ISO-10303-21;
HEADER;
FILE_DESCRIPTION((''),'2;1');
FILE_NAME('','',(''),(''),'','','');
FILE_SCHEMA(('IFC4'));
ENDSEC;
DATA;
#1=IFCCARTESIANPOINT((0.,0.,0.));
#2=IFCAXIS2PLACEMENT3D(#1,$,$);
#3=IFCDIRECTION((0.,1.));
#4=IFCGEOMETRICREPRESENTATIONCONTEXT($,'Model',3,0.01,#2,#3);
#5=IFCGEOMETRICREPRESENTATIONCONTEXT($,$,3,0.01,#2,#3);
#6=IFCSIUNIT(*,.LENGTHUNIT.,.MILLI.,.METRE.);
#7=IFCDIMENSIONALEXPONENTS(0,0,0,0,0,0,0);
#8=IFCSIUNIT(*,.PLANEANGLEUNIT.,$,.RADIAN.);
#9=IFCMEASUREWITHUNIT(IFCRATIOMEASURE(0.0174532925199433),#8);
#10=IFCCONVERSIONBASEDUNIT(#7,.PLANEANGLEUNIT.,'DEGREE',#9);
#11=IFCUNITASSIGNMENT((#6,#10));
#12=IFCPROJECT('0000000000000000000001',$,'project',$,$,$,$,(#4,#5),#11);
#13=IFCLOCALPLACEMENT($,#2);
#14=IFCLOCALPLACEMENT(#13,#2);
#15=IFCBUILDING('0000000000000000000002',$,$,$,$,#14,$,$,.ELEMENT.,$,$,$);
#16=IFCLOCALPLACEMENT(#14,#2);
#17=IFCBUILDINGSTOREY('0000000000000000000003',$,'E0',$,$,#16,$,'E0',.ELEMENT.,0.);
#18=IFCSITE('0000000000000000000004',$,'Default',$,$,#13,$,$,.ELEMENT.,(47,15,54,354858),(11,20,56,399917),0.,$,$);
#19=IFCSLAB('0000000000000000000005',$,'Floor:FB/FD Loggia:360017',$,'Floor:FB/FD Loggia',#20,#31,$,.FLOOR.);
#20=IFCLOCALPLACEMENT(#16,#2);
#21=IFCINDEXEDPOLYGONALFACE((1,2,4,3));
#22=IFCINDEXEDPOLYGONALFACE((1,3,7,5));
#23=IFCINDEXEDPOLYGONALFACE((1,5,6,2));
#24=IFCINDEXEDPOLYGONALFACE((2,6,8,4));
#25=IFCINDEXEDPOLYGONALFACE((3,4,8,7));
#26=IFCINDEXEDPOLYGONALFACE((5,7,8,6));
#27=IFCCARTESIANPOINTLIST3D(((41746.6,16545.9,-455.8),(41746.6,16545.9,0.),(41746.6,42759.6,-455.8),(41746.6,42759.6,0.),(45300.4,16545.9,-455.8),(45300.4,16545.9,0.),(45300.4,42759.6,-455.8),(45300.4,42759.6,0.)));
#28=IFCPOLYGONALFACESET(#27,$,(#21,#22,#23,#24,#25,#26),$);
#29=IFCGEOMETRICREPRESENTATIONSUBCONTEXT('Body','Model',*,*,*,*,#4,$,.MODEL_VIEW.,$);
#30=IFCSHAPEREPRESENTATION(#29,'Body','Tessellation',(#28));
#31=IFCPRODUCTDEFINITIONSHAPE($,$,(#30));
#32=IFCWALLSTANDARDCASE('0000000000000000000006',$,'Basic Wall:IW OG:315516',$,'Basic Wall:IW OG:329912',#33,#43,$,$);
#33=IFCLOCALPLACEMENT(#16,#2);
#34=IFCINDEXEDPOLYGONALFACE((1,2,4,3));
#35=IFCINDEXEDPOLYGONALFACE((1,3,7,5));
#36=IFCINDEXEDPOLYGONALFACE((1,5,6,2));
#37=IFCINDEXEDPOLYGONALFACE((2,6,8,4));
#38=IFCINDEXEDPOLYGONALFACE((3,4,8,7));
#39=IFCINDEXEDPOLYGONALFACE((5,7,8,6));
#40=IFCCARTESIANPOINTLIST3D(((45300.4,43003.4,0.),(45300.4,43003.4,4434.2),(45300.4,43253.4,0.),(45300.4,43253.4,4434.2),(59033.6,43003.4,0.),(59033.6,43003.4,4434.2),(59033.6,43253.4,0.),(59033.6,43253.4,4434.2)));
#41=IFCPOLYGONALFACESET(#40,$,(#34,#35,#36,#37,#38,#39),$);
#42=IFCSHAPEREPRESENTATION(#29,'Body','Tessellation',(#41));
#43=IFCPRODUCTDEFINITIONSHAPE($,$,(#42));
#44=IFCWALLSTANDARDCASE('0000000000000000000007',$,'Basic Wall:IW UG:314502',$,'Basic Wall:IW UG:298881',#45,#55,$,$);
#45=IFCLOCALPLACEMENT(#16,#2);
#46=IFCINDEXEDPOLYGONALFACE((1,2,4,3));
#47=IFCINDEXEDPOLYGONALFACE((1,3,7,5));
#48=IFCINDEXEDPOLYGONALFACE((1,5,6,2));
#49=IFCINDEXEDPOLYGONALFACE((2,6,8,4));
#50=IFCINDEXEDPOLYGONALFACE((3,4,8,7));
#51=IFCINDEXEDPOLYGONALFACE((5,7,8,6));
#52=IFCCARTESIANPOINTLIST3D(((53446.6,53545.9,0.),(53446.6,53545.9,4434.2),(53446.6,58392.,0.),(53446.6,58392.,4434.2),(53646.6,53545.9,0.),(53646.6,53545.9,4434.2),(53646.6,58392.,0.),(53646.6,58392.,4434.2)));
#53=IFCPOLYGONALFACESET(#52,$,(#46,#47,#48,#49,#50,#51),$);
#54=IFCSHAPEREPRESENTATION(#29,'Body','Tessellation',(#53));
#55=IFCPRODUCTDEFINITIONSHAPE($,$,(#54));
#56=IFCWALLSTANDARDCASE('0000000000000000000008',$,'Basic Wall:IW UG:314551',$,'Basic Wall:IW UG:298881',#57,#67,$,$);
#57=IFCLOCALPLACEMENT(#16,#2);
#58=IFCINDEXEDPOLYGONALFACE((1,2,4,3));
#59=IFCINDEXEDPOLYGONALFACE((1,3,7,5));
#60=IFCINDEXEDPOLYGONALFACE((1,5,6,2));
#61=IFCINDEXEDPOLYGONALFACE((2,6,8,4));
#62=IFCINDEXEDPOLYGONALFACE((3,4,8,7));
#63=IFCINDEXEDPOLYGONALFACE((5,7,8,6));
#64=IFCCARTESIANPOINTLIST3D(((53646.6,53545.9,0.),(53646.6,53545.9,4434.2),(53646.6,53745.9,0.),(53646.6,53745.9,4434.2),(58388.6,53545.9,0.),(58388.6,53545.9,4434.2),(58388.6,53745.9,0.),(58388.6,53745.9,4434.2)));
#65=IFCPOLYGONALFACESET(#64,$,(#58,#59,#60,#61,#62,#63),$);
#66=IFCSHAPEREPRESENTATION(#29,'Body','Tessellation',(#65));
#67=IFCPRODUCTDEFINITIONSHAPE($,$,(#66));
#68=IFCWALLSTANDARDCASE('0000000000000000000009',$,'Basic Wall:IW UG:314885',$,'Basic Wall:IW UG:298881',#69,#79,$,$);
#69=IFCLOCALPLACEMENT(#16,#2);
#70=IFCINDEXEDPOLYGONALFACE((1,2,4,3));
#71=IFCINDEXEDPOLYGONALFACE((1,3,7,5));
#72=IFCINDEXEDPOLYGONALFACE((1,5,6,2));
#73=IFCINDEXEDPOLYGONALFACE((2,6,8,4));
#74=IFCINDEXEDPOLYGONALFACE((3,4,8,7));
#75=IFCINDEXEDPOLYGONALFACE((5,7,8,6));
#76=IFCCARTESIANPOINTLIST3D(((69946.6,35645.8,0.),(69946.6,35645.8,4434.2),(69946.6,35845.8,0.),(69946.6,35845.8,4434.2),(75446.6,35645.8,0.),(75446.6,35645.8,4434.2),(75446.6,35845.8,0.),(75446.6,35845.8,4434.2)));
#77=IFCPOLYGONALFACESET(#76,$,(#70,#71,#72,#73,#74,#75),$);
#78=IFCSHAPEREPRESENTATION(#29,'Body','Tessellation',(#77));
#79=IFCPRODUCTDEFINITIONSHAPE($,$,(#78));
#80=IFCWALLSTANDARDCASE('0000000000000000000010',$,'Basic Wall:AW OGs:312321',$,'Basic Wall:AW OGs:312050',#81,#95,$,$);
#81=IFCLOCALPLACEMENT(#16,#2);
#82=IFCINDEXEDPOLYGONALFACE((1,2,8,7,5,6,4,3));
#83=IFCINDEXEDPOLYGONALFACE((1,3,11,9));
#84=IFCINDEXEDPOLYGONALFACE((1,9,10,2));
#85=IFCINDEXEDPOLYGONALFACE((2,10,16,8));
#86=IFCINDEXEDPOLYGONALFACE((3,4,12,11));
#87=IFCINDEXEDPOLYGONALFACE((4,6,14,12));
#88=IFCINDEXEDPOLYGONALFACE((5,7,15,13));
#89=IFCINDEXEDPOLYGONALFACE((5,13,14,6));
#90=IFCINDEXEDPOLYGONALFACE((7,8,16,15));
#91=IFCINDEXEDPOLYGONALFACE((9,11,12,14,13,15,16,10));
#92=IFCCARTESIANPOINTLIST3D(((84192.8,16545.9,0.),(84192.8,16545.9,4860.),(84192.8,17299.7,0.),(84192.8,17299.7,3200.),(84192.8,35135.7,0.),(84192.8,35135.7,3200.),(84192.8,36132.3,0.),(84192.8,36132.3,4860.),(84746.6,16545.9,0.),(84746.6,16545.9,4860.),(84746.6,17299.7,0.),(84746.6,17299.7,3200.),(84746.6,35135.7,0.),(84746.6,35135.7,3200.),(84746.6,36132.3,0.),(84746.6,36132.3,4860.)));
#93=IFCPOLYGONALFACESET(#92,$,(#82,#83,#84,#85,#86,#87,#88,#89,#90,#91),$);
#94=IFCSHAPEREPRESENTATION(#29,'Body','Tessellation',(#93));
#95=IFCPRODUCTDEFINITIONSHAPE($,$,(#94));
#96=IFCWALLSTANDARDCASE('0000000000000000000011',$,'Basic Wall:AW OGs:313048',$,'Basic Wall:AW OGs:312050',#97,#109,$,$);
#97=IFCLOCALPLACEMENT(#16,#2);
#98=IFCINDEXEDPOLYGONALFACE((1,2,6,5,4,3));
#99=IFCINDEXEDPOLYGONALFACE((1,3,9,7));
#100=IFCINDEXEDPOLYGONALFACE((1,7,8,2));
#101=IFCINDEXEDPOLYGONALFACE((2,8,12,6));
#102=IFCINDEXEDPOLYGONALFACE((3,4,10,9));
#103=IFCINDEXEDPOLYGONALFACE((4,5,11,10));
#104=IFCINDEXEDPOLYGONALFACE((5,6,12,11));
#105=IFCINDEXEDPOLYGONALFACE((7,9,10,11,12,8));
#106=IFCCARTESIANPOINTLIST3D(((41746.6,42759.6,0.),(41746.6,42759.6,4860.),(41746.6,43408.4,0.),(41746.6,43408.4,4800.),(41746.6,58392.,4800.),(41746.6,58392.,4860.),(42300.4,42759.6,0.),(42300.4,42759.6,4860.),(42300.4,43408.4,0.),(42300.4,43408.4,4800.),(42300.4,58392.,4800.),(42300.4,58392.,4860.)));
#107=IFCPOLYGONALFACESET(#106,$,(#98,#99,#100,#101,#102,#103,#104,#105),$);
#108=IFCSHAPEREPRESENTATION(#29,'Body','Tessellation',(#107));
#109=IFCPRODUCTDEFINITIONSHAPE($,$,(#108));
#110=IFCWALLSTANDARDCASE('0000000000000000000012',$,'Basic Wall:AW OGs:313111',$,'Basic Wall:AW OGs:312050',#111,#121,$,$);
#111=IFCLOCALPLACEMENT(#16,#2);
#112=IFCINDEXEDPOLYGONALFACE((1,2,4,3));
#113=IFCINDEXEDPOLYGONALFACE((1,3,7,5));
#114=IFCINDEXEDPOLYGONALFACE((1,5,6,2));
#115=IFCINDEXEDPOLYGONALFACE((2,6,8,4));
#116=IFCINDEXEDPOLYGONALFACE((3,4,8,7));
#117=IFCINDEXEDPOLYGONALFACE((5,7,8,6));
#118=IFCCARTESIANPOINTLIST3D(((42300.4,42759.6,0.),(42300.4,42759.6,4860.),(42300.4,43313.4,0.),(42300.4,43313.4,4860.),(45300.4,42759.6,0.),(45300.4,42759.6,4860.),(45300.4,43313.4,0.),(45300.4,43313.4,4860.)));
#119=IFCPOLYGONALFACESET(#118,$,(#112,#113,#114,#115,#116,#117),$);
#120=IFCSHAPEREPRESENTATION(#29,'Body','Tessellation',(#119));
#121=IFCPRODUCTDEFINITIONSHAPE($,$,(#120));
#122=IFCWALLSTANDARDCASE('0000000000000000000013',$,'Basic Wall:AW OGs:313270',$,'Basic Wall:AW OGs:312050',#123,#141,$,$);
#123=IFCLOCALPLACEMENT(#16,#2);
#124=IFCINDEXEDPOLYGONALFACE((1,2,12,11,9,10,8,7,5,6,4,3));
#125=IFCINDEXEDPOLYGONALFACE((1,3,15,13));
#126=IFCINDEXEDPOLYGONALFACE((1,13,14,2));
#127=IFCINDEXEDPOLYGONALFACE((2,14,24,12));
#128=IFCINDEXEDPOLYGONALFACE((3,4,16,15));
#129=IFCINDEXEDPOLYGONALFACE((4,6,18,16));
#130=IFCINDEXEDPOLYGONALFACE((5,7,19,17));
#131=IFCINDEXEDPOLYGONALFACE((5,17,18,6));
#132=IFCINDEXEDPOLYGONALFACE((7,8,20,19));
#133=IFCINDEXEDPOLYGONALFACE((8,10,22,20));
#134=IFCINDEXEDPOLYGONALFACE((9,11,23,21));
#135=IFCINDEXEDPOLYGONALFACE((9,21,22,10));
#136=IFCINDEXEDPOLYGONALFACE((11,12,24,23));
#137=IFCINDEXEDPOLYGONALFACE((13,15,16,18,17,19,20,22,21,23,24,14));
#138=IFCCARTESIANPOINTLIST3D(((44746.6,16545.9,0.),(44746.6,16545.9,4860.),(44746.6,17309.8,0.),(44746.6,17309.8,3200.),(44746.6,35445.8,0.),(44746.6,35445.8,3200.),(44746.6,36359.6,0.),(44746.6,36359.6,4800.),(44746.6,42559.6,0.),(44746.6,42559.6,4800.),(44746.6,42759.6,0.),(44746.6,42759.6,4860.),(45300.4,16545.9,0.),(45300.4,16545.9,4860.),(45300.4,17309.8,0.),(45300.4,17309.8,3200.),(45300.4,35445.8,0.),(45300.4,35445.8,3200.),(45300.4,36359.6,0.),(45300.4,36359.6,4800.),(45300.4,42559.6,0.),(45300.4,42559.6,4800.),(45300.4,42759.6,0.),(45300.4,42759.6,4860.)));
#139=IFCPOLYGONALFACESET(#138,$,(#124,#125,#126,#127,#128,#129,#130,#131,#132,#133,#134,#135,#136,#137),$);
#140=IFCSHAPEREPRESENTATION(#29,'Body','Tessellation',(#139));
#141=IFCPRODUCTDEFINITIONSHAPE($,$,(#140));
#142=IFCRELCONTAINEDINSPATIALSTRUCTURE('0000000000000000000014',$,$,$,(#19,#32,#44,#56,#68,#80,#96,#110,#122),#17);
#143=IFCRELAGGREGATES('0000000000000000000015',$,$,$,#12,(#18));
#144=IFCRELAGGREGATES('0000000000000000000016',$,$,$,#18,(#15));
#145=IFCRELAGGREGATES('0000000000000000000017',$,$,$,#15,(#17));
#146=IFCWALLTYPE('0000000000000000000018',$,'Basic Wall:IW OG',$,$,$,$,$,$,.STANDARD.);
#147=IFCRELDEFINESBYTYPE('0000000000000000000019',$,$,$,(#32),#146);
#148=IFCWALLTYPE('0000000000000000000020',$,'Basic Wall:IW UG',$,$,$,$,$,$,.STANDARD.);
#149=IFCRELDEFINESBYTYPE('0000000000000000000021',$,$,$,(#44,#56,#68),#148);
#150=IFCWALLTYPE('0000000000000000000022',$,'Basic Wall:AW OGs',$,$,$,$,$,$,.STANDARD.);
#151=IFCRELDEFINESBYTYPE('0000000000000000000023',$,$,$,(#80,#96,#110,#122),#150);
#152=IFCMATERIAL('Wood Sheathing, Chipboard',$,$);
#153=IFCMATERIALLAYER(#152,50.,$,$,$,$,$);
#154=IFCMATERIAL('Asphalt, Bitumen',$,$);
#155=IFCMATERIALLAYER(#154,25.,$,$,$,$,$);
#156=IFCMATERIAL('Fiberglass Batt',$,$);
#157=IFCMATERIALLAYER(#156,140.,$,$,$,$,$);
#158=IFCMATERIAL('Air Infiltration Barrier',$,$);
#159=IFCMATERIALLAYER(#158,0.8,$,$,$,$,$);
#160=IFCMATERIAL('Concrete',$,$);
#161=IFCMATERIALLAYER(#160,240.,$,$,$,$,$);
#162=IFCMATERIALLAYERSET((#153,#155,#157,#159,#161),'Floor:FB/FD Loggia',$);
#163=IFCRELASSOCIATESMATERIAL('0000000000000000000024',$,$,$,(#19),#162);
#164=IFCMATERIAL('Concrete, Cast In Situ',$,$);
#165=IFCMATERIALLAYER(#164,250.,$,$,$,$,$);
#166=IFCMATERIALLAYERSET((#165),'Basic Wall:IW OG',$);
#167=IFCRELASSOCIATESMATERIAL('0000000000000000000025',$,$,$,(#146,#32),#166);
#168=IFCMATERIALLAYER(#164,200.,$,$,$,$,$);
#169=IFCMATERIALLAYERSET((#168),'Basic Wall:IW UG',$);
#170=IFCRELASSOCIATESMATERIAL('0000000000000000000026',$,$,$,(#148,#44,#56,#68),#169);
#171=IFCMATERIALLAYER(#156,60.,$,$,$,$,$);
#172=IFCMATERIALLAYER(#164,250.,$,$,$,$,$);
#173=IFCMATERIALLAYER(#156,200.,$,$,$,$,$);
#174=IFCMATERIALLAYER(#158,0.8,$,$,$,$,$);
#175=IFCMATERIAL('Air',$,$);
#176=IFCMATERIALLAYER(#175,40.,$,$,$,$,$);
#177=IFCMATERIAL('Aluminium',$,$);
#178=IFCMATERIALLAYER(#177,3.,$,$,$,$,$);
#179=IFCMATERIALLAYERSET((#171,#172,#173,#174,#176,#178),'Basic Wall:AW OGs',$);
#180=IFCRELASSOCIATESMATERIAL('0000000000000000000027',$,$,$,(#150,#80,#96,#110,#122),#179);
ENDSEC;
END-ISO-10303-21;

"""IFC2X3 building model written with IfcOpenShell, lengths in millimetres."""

from ifc_helpers import new_model, entity, si_unit, converted_unit, direction, frame, frame_2d, origin, place, context, subcontext, project, spatial, polyline, rectangle, extrude, clip, bounded_halfspace, material, layer, layer_set, layer_usage, type_object, element, save


model = new_model("IFC2X3")

# Units and contexts
model_context = context("Model", 3, precision=0.01, world=origin(), true_north=direction((0.0, 1.0)))
context_of_model = context(None, 3, precision=0.01, world=origin(), true_north=direction((0.0, 1.0)))
body_context = subcontext(model_context, "Body", "Model", "MODEL_VIEW")
ifc_project = project(units=[si_unit("LENGTHUNIT", "METRE", prefix="MILLI"), converted_unit("PLANEANGLEUNIT", "DEGREE", entity("IfcRatioMeasure", 0.0174532925199433), si_unit("PLANEANGLEUNIT", "RADIAN"), dimensions=[0, 0, 0, 0, 0, 0, 0])], contexts=[model_context, context_of_model])

# Site, building, storey
site_placement = place(None, origin())
site = spatial("IfcSite", under=ifc_project, at=site_placement, Name="Default", CompositionType="ELEMENT", RefLatitude=(47, 15, 54, 354858), RefLongitude=(11, 20, 56, 399917), RefElevation=0.0)
building_placement = place(site_placement, origin())
building = spatial("IfcBuilding", under=site, at=building_placement, CompositionType="ELEMENT")
storey_placement = place(building_placement, origin())
storey = spatial("IfcBuildingStorey", under=building, at=storey_placement, Name="E0", LongName="E0", CompositionType="ELEMENT", Elevation=0.0)

# Slab
ifc_material_1 = material(Name="Air Infiltration Barrier")
ifc_material_2 = material(Name="Fiberglass Batt")
ifc_material_3 = material(Name="Concrete")
ifc_material_4 = material(Name="Wood Sheathing, Chipboard")
ifc_layer_1 = layer(ifc_material_4, 50.0)
ifc_material_5 = material(Name="Asphalt, Bitumen")
ifc_layer_2 = layer(ifc_material_5, 25.0)
ifc_layer_3 = layer(ifc_material_2, 140.0)
ifc_layer_4 = layer(ifc_material_1, 0.8)
ifc_layer_5 = layer(ifc_material_3, 240.0)
ifc_layer_set_1 = layer_set([ifc_layer_1, ifc_layer_2, ifc_layer_3, ifc_layer_4, ifc_layer_5], Name="Floor:FB/FD Loggia")
ifc_layer_usage_1 = layer_usage(ifc_layer_set_1, "AXIS3", "POSITIVE", 0.0)
slab_1_placement = place(storey_placement, origin())
element("IfcSlab", 1, at=slab_1_placement, inside=storey, material=ifc_layer_usage_1, Name="Floor:FB/FD Loggia:360017", ObjectType="Floor:FB/FD Loggia", PredefinedType="FLOOR", context=body_context, shape_type="SweptSolid", body=[
    extrude(rectangle(XDim=26213.8, YDim=3553.8, at=frame_2d((0.0, 0.0), x_axis=(1.0, 0.0))), frame((43523.5, 29652.7, 0.0), z_axis=(0.0, 0.0, -1.0), x_axis=(0.0, 1.0, 0.0)), (0.0, 0.0, 1.0), 455.8),
])

# Walls
ifc_material_6 = material(Name="Concrete, Cast In Situ")
ifc_layer_6 = layer(ifc_material_6, 250.0)
ifc_layer_set_2 = layer_set([ifc_layer_6], Name="Basic Wall:IW OG")
wall_type_1 = type_object("IfcWallType", Name="Basic Wall:IW OG", PredefinedType="STANDARD", material=ifc_layer_set_2)
ifc_layer_usage_2 = layer_usage(ifc_layer_set_2, "AXIS2", "NEGATIVE", 125.0)
wall_1_placement = place(storey_placement, frame((45300.4, 43128.4, 0.0)))
element("IfcWallStandardCase", 2, at=wall_1_placement, inside=storey, type_object=wall_type_1, material=ifc_layer_usage_2, Name="Basic Wall:IW OG:315516", ObjectType="Basic Wall:IW OG:329912", context=body_context, shape_type="Clipping", body=[
    clip(extrude(rectangle(XDim=13733.2, YDim=250.0, at=frame_2d((6866.6, 0.0), x_axis=(-1.0, 0.0))), origin(), (0.0, 0.0, 1.0), 4434.2), bounded_halfspace(frame((0.0, -125.0, 4434.2), z_axis=(0.0, 0.0, -1.0), x_axis=(1.0, 0.0, 0.0)), True, frame((0.0, -125.0, 4434.2)), polyline([(0.0, 0.0), (7986.2, 0.0), (7986.2, 250.0), (0.0, 250.0), (0.0, 0.0)]))),
])
ifc_layer_7 = layer(ifc_material_6, 200.0)
ifc_layer_set_3 = layer_set([ifc_layer_7], Name="Basic Wall:IW UG")
ifc_layer_usage_3 = layer_usage(ifc_layer_set_3, "AXIS2", "NEGATIVE", 100.0)
wall_type_2 = type_object("IfcWallType", Name="Basic Wall:IW UG", PredefinedType="STANDARD", material=ifc_layer_set_3)
wall_2_placement = place(storey_placement, frame((53546.6, 58392.0, 0.0), z_axis=(0.0, 0.0, 1.0), x_axis=(0.0, -1.0, 0.0)))
element("IfcWallStandardCase", 3, at=wall_2_placement, inside=storey, type_object=wall_type_2, material=ifc_layer_usage_3, Name="Basic Wall:IW UG:314502", ObjectType="Basic Wall:IW UG:298881", context=body_context, shape_type="Clipping", body=[
    clip(extrude(rectangle(XDim=4846.2, YDim=200.0, at=frame_2d((2423.1, 0.0), x_axis=(-1.0, 0.0))), origin(), (0.0, 0.0, 1.0), 4434.2), bounded_halfspace(frame((0.0, -100.0, 4434.2), z_axis=(0.0, 0.0, -1.0), x_axis=(0.0, 1.0, 0.0)), True, frame((0.0, -100.0, 4434.2)), polyline([(0.0, 0.0), (4846.2, 0.0), (4846.2, 200.0), (4646.2, 200.0), (0.0, 200.0), (0.0, 0.0)]))),
])
ifc_layer_usage_4 = layer_usage(ifc_layer_set_3, "AXIS2", "NEGATIVE", 100.0)
wall_3_placement = place(storey_placement, frame((53646.6, 53645.9, 0.0)))
element("IfcWallStandardCase", 4, at=wall_3_placement, inside=storey, type_object=wall_type_2, material=ifc_layer_usage_4, Name="Basic Wall:IW UG:314551", ObjectType="Basic Wall:IW UG:298881", context=body_context, shape_type="Clipping", body=[
    clip(extrude(rectangle(XDim=4742.0, YDim=200.0, at=frame_2d((2371.0, 0.0), x_axis=(-1.0, 0.0))), origin(), (0.0, 0.0, 1.0), 4434.2), bounded_halfspace(frame((0.0, -100.0, 4434.2), z_axis=(0.0, 0.0, -1.0), x_axis=(1.0, 0.0, 0.0)), True, frame((0.0, -100.0, 4434.2)), polyline([(0.0, 0.0), (4742.0, 0.0), (4742.0, 200.0), (0.0, 200.0), (0.0, 0.0)]))),
])
ifc_layer_usage_5 = layer_usage(ifc_layer_set_3, "AXIS2", "POSITIVE", -100.0)
wall_4_placement = place(storey_placement, frame((69946.6, 35745.8, 0.0)))
element("IfcWallStandardCase", 5, at=wall_4_placement, inside=storey, type_object=wall_type_2, material=ifc_layer_usage_5, Name="Basic Wall:IW UG:314885", ObjectType="Basic Wall:IW UG:298881", context=body_context, shape_type="Clipping", body=[
    clip(extrude(rectangle(XDim=5500.0, YDim=200.0, at=frame_2d((2750.0, 0.0), x_axis=(-1.0, 0.0))), origin(), (0.0, 0.0, 1.0), 4434.2), bounded_halfspace(frame((0.0, -100.0, 4434.2), z_axis=(0.0, 0.0, -1.0), x_axis=(1.0, 0.0, 0.0)), True, frame((0.0, -100.0, 4434.2)), polyline([(0.0, 0.0), (5500.0, 0.0), (5500.0, 200.0), (0.0, 200.0), (0.0, 0.0)]))),
])

# Walls, openings
ifc_layer_8 = layer(ifc_material_2, 60.0)
ifc_layer_9 = layer(ifc_material_6, 250.0)
ifc_layer_10 = layer(ifc_material_2, 200.0)
ifc_layer_11 = layer(ifc_material_1, 0.8)
ifc_material_7 = material(Name="Air")
ifc_layer_12 = layer(ifc_material_7, 40.0)
ifc_material_8 = material(Name="Aluminium")
ifc_layer_13 = layer(ifc_material_8, 3.0)
ifc_layer_set_4 = layer_set([ifc_layer_8, ifc_layer_9, ifc_layer_10, ifc_layer_11, ifc_layer_12, ifc_layer_13], Name="Basic Wall:AW OGs")
ifc_layer_usage_6 = layer_usage(ifc_layer_set_4, "AXIS2", "NEGATIVE", 276.9)
wall_type_3 = type_object("IfcWallType", Name="Basic Wall:AW OGs", PredefinedType="STANDARD", material=ifc_layer_set_4)
wall_5_placement = place(storey_placement, frame((84469.7, 16545.9, 0.0), z_axis=(0.0, 0.0, 1.0), x_axis=(0.0, 1.0, 0.0)))
wall_5 = element("IfcWallStandardCase", 6, at=wall_5_placement, inside=storey, type_object=wall_type_3, material=ifc_layer_usage_6, Name="Basic Wall:AW OGs:312321", ObjectType="Basic Wall:AW OGs:312050", context=body_context, shape_type="SweptSolid", body=[
    extrude(rectangle(XDim=19586.5, YDim=553.8, at=frame_2d((9793.2, 0.0), x_axis=(-1.0, 0.0))), origin(), (0.0, 0.0, 1.0), 4860.0),
])
opening_1_placement = place(wall_5_placement, frame((18589.8, 276.9, 0.0)))
element("IfcOpeningElement", 7, at=opening_1_placement, cuts=wall_5, ObjectType="Opening", context=body_context, shape_type="SweptSolid", body=[
    extrude(rectangle(XDim=3200.0, YDim=17836.0, at=frame_2d((1600.0, 8918.0), x_axis=(-1.0, 0.0))), frame((0.0, 0.0, 0.0), z_axis=(0.0, -1.0, 0.0), x_axis=(0.0, 0.0, 1.0)), (0.0, 0.0, 1.0), 553.8),
])
ifc_layer_usage_7 = layer_usage(ifc_layer_set_4, "AXIS2", "NEGATIVE", 276.9)
wall_6_placement = place(storey_placement, frame((42023.5, 58392.0, 0.0), z_axis=(0.0, 0.0, 1.0), x_axis=(0.0, -1.0, 0.0)))
wall_6 = element("IfcWallStandardCase", 8, at=wall_6_placement, inside=storey, type_object=wall_type_3, material=ifc_layer_usage_7, Name="Basic Wall:AW OGs:313048", ObjectType="Basic Wall:AW OGs:312050", context=body_context, shape_type="SweptSolid", body=[
    extrude(rectangle(XDim=15632.4, YDim=553.8, at=frame_2d((7816.2, 0.0), x_axis=(-1.0, 0.0))), origin(), (0.0, 0.0, 1.0), 4860.0),
])
opening_2_placement = place(wall_6_placement, frame((14983.6, 276.9, 0.0)))
element("IfcOpeningElement", 9, at=opening_2_placement, cuts=wall_6, ObjectType="Opening", context=body_context, shape_type="SweptSolid", body=[
    extrude(rectangle(XDim=4800.0, YDim=15000.0, at=frame_2d((2400.0, 7500.0), x_axis=(-1.0, 0.0))), frame((0.0, 0.0, 0.0), z_axis=(0.0, -1.0, 0.0), x_axis=(0.0, 0.0, 1.0)), (0.0, 0.0, 1.0), 553.8),
])

# Wall
ifc_layer_usage_8 = layer_usage(ifc_layer_set_4, "AXIS2", "NEGATIVE", 276.9)
wall_7_placement = place(storey_placement, frame((42300.4, 43036.5, 0.0)))
element("IfcWallStandardCase", 10, at=wall_7_placement, inside=storey, type_object=wall_type_3, material=ifc_layer_usage_8, Name="Basic Wall:AW OGs:313111", ObjectType="Basic Wall:AW OGs:312050", context=body_context, shape_type="SweptSolid", body=[
    extrude(rectangle(XDim=3000.0, YDim=553.8, at=frame_2d((1500.0, 0.0), x_axis=(-1.0, 0.0))), origin(), (0.0, 0.0, 1.0), 4860.0),
])

# Wall, openings
ifc_layer_usage_9 = layer_usage(ifc_layer_set_4, "AXIS2", "NEGATIVE", 276.9)
wall_8_placement = place(storey_placement, frame((45023.5, 42759.6, 0.0), z_axis=(0.0, 0.0, 1.0), x_axis=(0.0, -1.0, 0.0)))
wall_8 = element("IfcWallStandardCase", 11, at=wall_8_placement, inside=storey, type_object=wall_type_3, material=ifc_layer_usage_9, Name="Basic Wall:AW OGs:313270", ObjectType="Basic Wall:AW OGs:312050", context=body_context, shape_type="SweptSolid", body=[
    extrude(rectangle(XDim=26213.8, YDim=553.8, at=frame_2d((13106.9, 0.0), x_axis=(-1.0, 0.0))), origin(), (0.0, 0.0, 1.0), 4860.0),
])
opening_3_placement = place(wall_8_placement, frame((25449.8, 276.9, 0.0)))
element("IfcOpeningElement", 12, at=opening_3_placement, cuts=wall_8, ObjectType="Opening", context=body_context, shape_type="SweptSolid", body=[
    extrude(rectangle(XDim=3200.0, YDim=18136.0, at=frame_2d((1600.0, 9068.0), x_axis=(-1.0, 0.0))), frame((0.0, 0.0, 0.0), z_axis=(0.0, -1.0, 0.0), x_axis=(0.0, 0.0, 1.0)), (0.0, 0.0, 1.0), 553.8),
])
opening_4_placement = place(wall_8_placement, frame((6400.0, 276.9, 0.0)))
element("IfcOpeningElement", 13, at=opening_4_placement, cuts=wall_8, ObjectType="Opening", context=body_context, shape_type="SweptSolid", body=[
    extrude(rectangle(XDim=4800.0, YDim=6200.0, at=frame_2d((2400.0, 3100.0), x_axis=(-1.0, 0.0))), frame((0.0, 0.0, 0.0), z_axis=(0.0, -1.0, 0.0), x_axis=(0.0, 0.0, 1.0)), (0.0, 0.0, 1.0), 553.8),
])

save(model, "model.ifc")
